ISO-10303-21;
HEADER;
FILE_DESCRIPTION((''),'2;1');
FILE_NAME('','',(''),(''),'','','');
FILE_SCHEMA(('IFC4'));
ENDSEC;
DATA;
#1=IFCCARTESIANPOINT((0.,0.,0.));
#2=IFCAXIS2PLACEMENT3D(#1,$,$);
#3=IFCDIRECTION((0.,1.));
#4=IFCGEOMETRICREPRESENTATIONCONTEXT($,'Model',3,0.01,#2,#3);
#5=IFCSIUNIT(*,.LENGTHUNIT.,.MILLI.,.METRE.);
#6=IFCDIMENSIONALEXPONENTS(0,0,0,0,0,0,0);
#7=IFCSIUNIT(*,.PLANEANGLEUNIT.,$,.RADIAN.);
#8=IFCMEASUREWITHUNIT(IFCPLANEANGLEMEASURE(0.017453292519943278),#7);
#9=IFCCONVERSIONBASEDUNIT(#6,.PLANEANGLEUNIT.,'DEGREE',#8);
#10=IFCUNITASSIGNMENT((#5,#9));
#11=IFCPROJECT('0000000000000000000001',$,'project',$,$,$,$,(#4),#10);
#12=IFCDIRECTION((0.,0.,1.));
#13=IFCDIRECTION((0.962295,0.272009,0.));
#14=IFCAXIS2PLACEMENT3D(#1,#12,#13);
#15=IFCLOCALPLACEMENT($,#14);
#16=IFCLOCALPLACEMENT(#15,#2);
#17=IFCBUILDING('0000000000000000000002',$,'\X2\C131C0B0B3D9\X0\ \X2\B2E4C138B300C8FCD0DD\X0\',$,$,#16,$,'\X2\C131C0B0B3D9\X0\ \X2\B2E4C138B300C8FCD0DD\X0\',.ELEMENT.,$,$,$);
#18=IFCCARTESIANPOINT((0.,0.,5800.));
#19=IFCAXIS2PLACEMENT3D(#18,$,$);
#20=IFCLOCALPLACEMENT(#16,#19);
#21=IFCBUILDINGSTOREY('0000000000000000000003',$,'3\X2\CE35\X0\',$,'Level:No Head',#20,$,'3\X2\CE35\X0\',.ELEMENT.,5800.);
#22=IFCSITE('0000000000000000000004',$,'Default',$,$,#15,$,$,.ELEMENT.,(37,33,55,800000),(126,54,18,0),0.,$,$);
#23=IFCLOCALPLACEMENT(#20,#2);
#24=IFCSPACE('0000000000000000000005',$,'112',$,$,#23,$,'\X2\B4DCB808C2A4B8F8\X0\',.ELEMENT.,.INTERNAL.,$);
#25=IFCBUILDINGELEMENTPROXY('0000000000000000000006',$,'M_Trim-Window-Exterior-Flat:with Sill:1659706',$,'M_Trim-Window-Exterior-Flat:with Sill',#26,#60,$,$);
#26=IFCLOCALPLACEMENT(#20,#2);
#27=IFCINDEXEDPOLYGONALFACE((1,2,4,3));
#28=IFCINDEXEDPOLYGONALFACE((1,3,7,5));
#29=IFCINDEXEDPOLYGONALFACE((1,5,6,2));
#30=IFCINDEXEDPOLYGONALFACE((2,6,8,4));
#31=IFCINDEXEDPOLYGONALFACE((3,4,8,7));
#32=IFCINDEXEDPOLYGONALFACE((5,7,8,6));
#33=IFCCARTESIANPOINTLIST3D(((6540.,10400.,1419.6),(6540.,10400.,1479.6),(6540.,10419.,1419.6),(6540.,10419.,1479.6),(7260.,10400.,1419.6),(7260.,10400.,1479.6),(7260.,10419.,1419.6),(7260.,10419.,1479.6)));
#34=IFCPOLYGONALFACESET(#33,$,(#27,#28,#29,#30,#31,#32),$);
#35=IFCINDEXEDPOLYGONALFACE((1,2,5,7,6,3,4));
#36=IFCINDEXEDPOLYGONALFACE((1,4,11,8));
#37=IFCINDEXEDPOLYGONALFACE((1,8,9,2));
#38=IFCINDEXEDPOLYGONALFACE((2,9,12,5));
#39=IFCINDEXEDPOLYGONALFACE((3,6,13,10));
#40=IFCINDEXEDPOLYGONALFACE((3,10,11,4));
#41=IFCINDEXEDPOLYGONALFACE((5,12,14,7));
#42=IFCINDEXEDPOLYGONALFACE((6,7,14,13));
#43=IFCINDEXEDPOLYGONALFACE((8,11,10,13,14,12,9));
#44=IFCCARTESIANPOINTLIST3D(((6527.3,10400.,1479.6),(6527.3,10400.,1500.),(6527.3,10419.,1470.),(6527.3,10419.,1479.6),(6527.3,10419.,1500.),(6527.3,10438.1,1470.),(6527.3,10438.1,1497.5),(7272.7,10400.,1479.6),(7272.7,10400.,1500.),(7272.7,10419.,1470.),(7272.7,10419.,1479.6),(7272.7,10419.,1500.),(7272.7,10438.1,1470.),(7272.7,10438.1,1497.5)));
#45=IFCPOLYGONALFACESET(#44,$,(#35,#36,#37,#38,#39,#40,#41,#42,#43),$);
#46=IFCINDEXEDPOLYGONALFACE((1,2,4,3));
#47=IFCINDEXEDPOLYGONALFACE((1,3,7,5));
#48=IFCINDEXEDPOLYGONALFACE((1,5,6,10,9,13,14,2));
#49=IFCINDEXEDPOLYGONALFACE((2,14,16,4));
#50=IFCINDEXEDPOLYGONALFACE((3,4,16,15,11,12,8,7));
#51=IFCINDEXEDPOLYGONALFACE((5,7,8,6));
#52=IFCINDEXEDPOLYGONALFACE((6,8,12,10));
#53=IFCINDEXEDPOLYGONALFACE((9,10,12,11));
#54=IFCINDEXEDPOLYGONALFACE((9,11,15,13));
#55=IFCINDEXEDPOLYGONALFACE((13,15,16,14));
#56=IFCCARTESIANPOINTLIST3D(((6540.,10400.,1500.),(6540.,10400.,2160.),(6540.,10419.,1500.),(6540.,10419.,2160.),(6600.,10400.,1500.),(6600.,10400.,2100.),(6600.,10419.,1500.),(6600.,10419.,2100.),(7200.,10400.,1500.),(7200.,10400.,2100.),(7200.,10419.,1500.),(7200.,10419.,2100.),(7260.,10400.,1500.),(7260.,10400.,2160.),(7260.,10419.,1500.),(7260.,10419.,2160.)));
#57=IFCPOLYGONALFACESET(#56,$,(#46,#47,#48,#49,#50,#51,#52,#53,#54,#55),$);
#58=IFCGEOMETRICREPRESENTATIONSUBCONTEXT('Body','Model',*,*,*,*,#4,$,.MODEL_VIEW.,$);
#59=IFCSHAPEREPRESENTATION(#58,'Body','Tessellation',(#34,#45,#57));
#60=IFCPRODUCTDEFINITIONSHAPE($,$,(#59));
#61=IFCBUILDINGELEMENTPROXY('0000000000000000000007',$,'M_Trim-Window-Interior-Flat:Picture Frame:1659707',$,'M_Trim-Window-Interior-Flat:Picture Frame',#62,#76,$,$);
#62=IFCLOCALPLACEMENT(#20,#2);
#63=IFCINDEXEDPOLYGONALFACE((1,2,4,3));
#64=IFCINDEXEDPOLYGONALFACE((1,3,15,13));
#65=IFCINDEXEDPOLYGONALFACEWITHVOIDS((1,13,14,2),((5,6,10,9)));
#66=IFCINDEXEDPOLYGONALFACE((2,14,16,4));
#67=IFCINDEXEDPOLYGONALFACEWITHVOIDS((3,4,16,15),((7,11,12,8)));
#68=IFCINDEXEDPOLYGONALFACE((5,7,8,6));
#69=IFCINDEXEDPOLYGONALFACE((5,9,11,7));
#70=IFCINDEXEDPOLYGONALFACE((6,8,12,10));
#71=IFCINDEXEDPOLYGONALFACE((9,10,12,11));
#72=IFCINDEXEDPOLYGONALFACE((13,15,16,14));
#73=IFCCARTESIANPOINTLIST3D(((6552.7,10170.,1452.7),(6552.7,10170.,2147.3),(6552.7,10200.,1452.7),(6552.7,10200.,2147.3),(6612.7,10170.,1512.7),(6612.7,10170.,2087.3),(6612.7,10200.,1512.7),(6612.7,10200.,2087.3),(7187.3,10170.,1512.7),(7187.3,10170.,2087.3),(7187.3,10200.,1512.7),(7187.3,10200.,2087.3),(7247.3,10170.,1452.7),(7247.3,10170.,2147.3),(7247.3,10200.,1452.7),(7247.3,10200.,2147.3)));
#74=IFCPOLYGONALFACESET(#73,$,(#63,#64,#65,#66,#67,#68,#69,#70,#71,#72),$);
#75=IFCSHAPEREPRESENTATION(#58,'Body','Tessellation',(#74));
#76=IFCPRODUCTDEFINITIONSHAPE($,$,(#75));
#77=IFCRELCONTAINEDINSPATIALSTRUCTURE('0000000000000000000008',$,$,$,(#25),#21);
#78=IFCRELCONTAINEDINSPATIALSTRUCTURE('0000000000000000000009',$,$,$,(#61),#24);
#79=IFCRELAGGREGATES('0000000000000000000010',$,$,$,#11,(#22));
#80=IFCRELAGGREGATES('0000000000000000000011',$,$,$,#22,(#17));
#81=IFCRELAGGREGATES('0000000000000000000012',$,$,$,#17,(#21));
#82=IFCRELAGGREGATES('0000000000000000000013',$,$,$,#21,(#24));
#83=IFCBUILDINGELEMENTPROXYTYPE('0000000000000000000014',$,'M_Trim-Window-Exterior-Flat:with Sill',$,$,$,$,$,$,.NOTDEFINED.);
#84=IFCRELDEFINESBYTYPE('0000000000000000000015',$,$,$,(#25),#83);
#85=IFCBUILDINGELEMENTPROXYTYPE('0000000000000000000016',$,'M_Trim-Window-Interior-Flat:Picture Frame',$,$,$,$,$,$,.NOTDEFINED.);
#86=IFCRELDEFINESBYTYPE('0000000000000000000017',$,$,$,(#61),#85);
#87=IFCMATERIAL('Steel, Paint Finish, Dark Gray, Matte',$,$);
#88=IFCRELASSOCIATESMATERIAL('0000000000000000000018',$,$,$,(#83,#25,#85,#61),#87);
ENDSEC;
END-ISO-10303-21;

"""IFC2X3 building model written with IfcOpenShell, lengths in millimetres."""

from ifc_helpers import new_model, entity, si_unit, converted_unit, direction, frame, frame_2d, origin, place, context, subcontext, project, spatial, polyline, rectangle, outline, extrude, source, transform, mapped, material, type_object, type_shapes, element, save


model = new_model("IFC2X3")

# Units and contexts
model_context = context("Model", 3, precision=0.01, world=origin(), true_north=direction((0.0, 1.0)))
body_context = subcontext(model_context, "Body", "Model", "MODEL_VIEW")
ifc_project = project(units=[si_unit("LENGTHUNIT", "METRE", prefix="MILLI"), converted_unit("PLANEANGLEUNIT", "DEGREE", entity("IfcPlaneAngleMeasure", 0.017453292519943278), si_unit("PLANEANGLEUNIT", "RADIAN"), dimensions=[0, 0, 0, 0, 0, 0, 0])], contexts=[model_context])

# Site, building, storey
site_placement = place(None, frame((0.0, 0.0, 0.0), z_axis=(0.0, 0.0, 1.0), x_axis=(0.962295, 0.272009, 0.0)))
site = spatial("IfcSite", under=ifc_project, at=site_placement, Name="Default", CompositionType="ELEMENT", RefLatitude=(37, 33, 55, 800000), RefLongitude=(126, 54, 18, 0), RefElevation=0.0)
building_placement = place(site_placement, origin())
building = spatial("IfcBuilding", under=site, at=building_placement, Name="성산동 다세대주택", LongName="성산동 다세대주택", CompositionType="ELEMENT")
storey_placement = place(building_placement, frame((0.0, 0.0, 5800.0)))
storey = spatial("IfcBuildingStorey", under=building, at=storey_placement, Name="3층", ObjectType="Level:No Head", LongName="3층", CompositionType="ELEMENT", Elevation=5800.0)

# Shared definitions
space_1_placement = place(storey_placement, origin())
space_1 = spatial("IfcSpace", under=storey, at=space_1_placement, Name="112", LongName="드레스룸", CompositionType="ELEMENT", InteriorOrExteriorSpace="INTERNAL")

# Shared definitions
ifc_material_1 = material(Name="Steel, Paint Finish, Dark Gray, Matte")

# Building element proxies
building_element_proxy_type_1 = type_object("IfcBuildingElementProxyType", Name="M_Trim-Window-Exterior-Flat:with Sill", PredefinedType="NOTDEFINED", material=ifc_material_1)
shared_shape_1 = source(origin(), body_context, "Body", "SweptSolid", [
    extrude(rectangle(XDim=720.0, YDim=60.0, at=frame_2d((0.0, 0.0), x_axis=(1.0, 0.0))), frame((0.0, -650.4, 0.0), z_axis=(0.0, 0.0, 1.0), x_axis=(-1.0, 0.0, 0.0)), (0.0, 0.0, 1.0), 19.0),
    extrude(outline(polyline([(-19.0, -15.2), (0.0, -15.2), (0.0, -5.7), (19.0, -5.7), (19.0, 14.8), (0.0, 14.8), (-19.0, 12.3), (-19.0, -15.2)])), frame((-372.7, -614.8, 19.0), z_axis=(1.0, 0.0, 0.0), x_axis=(0.0, 0.0, -1.0)), (0.0, 0.0, 1.0), 745.4),
    extrude(outline(polyline([(-345.0, -360.0), (315.0, -360.0), (315.0, -300.0), (-285.0, -300.0), (-285.0, 300.0), (315.0, 300.0), (315.0, 360.0), (-345.0, 360.0), (-345.0, -360.0)])), frame((0.0, -285.0, 0.0), z_axis=(0.0, 0.0, 1.0), x_axis=(0.0, -1.0, 0.0)), (0.0, 0.0, 1.0), 19.0),
])
type_shapes(building_element_proxy_type_1, [shared_shape_1])
proxy_1_placement = place(storey_placement, frame((6900.0, 10400.0, 2100.0), z_axis=(0.0, 1.0, 0.0), x_axis=(-1.0, 0.0, 0.0)))
element("IfcBuildingElementProxy", 1, at=proxy_1_placement, inside=storey, type_object=building_element_proxy_type_1, material=ifc_material_1, Name="M_Trim-Window-Exterior-Flat:with Sill:1659706", ObjectType="M_Trim-Window-Exterior-Flat:with Sill", context=body_context, shape_type="MappedRepresentation", body=[
    mapped(shared_shape_1, transform((0.0, 0.0, 0.0), scale=1.0)),
])
building_element_proxy_type_2 = type_object("IfcBuildingElementProxyType", Name="M_Trim-Window-Interior-Flat:Picture Frame", PredefinedType="NOTDEFINED", material=ifc_material_1)
shared_shape_2 = source(origin(), body_context, "Body", "SweptSolid", [
    extrude(outline(polyline([(-347.3, -347.3), (347.3, -347.3), (347.3, 347.3), (-347.3, 347.3), (-347.3, -347.3)]), holes=[polyline([(-287.3, -287.3), (-287.3, 287.3), (287.3, 287.3), (287.3, -287.3), (-287.3, -287.3)])]), frame((0.0, -300.0, 0.0), z_axis=(0.0, 0.0, 1.0), x_axis=(-1.0, 0.0, 0.0)), (0.0, 0.0, 1.0), 30.0),
])
type_shapes(building_element_proxy_type_2, [shared_shape_2])
proxy_2_placement = place(space_1_placement, frame((6900.0, 10200.0, 2100.0), z_axis=(0.0, -1.0, 0.0), x_axis=(1.0, 0.0, 0.0)))
element("IfcBuildingElementProxy", 2, at=proxy_2_placement, inside=space_1, type_object=building_element_proxy_type_2, material=ifc_material_1, Name="M_Trim-Window-Interior-Flat:Picture Frame:1659707", ObjectType="M_Trim-Window-Interior-Flat:Picture Frame", context=body_context, shape_type="MappedRepresentation", body=[
    mapped(shared_shape_2, transform((0.0, 0.0, 0.0), scale=1.0)),
])

save(model, "model.ifc")
